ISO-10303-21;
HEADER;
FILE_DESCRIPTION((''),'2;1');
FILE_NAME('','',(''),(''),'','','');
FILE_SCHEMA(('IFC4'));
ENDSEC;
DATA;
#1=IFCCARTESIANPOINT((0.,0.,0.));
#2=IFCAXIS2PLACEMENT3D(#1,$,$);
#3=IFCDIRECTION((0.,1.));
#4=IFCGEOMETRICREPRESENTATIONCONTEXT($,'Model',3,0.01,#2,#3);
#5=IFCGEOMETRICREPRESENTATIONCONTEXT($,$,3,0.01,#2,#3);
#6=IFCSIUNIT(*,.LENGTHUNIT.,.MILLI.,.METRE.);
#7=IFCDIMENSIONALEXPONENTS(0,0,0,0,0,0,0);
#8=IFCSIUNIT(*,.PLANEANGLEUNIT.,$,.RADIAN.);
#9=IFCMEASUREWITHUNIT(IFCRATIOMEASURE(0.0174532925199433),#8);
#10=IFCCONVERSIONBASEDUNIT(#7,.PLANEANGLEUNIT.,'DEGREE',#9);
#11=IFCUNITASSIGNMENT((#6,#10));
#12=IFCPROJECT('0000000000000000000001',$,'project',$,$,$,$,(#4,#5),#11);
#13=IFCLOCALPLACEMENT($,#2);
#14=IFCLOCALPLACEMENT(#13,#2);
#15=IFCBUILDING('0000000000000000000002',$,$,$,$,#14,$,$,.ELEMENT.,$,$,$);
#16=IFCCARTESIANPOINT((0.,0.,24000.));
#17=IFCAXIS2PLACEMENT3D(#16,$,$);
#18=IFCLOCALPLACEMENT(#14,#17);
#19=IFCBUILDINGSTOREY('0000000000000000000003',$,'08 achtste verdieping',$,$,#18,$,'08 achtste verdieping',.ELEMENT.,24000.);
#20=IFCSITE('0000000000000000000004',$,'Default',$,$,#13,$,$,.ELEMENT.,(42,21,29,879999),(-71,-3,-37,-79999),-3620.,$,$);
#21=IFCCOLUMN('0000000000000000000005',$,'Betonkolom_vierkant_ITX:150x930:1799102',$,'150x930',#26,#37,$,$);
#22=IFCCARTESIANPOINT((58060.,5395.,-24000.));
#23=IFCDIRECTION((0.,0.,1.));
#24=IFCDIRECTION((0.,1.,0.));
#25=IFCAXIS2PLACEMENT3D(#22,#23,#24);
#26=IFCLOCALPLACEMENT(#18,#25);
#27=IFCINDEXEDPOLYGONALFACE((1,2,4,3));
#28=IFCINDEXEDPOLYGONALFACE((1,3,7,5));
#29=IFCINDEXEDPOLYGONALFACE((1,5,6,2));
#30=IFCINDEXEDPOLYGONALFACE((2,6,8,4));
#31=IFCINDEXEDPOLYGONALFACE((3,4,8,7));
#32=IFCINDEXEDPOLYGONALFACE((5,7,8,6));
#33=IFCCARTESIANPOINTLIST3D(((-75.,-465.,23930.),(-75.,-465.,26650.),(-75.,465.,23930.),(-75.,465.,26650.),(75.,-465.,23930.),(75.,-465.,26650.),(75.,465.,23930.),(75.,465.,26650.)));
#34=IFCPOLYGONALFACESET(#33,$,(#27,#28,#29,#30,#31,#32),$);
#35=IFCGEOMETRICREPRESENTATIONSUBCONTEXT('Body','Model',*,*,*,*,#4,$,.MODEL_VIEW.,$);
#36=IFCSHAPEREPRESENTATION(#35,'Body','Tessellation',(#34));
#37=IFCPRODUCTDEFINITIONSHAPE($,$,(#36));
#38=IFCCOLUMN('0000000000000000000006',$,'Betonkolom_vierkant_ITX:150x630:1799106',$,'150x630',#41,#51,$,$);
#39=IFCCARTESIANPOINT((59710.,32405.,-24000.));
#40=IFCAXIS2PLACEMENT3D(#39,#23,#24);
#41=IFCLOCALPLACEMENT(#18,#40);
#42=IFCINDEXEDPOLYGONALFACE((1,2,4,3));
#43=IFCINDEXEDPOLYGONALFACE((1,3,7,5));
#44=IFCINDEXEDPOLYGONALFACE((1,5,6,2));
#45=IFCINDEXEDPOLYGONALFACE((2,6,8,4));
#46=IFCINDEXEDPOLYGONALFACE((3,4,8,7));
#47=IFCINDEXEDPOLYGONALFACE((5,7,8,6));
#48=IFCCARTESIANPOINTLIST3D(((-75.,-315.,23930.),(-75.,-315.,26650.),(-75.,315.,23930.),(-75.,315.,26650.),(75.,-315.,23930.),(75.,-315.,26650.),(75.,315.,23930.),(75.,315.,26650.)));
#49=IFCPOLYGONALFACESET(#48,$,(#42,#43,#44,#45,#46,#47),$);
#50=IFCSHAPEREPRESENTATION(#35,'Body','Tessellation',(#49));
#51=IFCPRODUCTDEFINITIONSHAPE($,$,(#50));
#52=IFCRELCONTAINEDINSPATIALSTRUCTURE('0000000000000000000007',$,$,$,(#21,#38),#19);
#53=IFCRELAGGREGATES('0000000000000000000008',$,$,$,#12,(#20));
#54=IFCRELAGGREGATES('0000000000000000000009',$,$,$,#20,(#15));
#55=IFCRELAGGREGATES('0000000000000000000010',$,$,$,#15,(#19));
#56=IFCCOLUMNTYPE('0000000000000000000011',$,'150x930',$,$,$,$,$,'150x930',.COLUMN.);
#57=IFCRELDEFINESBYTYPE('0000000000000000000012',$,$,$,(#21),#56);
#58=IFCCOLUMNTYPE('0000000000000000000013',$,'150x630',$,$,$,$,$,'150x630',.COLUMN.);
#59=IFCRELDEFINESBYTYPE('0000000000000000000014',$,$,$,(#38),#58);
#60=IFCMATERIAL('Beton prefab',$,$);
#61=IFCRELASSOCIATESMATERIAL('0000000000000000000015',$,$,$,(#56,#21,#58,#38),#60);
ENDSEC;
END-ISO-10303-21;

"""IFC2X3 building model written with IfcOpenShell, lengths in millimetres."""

from ifc_helpers import new_model, entity, si_unit, converted_unit, direction, frame, origin, origin_2d_with_axis, place, context, subcontext, project, spatial, rectangle, extrude, source, transform, mapped, material, type_object, type_shapes, element, save


model = new_model("IFC2X3")

# Units and contexts
model_context = context("Model", 3, precision=0.01, world=origin(), true_north=direction((0.0, 1.0)))
context_of_model = context(None, 3, precision=0.01, world=origin(), true_north=direction((0.0, 1.0)))
body_context = subcontext(model_context, "Body", "Model", "MODEL_VIEW")
ifc_project = project(units=[si_unit("LENGTHUNIT", "METRE", prefix="MILLI"), converted_unit("PLANEANGLEUNIT", "DEGREE", entity("IfcRatioMeasure", 0.0174532925199433), si_unit("PLANEANGLEUNIT", "RADIAN"), dimensions=[0, 0, 0, 0, 0, 0, 0])], contexts=[model_context, context_of_model])

# Site, building, storey
site_placement = place(None, origin())
site = spatial("IfcSite", under=ifc_project, at=site_placement, Name="Default", CompositionType="ELEMENT", RefLatitude=(42, 21, 29, 879999), RefLongitude=(-71, -3, -37, -79999), RefElevation=-3620.0)
building_placement = place(site_placement, origin())
building = spatial("IfcBuilding", under=site, at=building_placement, CompositionType="ELEMENT")
storey_placement = place(building_placement, frame((0.0, 0.0, 24000.0)))
storey = spatial("IfcBuildingStorey", under=building, at=storey_placement, Name="08 achtste verdieping", LongName="08 achtste verdieping", CompositionType="ELEMENT", Elevation=24000.0)

# Columns
ifc_material_1 = material(Name="Beton prefab")
column_type_1 = type_object("IfcColumnType", Name="150x930", ElementType="150x930", PredefinedType="COLUMN", material=ifc_material_1)
shared_shape_1 = source(origin(), body_context, "Body", "SweptSolid", [
    extrude(rectangle(XDim=930.0, YDim=150.0, at=origin_2d_with_axis()), frame((0.0, 0.0, 23930.0), z_axis=(0.0, 0.0, 1.0), x_axis=(0.0, -1.0, 0.0)), (0.0, 0.0, 1.0), 2720.0),
])
type_shapes(column_type_1, [shared_shape_1])
column_1_placement = place(storey_placement, frame((58060.0, 5395.0, -24000.0), z_axis=(0.0, 0.0, 1.0), x_axis=(0.0, 1.0, 0.0)))
element("IfcColumn", 1, at=column_1_placement, inside=storey, type_object=column_type_1, material=ifc_material_1, Name="Betonkolom_vierkant_ITX:150x930:1799102", ObjectType="150x930", context=body_context, shape_type="MappedRepresentation", body=[
    mapped(shared_shape_1, transform((0.0, 0.0, 0.0), scale=1.0)),
])
column_type_2 = type_object("IfcColumnType", Name="150x630", ElementType="150x630", PredefinedType="COLUMN", material=ifc_material_1)
shared_shape_2 = source(origin(), body_context, "Body", "SweptSolid", [
    extrude(rectangle(XDim=630.0, YDim=150.0, at=origin_2d_with_axis()), frame((0.0, 0.0, 23930.0), z_axis=(0.0, 0.0, 1.0), x_axis=(0.0, -1.0, 0.0)), (0.0, 0.0, 1.0), 2720.0),
])
type_shapes(column_type_2, [shared_shape_2])
column_2_placement = place(storey_placement, frame((59710.0, 32405.0, -24000.0), z_axis=(0.0, 0.0, 1.0), x_axis=(0.0, 1.0, 0.0)))
element("IfcColumn", 2, at=column_2_placement, inside=storey, type_object=column_type_2, material=ifc_material_1, Name="Betonkolom_vierkant_ITX:150x630:1799106", ObjectType="150x630", context=body_context, shape_type="MappedRepresentation", body=[
    mapped(shared_shape_2, transform((0.0, 0.0, 0.0), scale=1.0)),
])

save(model, "model.ifc")
